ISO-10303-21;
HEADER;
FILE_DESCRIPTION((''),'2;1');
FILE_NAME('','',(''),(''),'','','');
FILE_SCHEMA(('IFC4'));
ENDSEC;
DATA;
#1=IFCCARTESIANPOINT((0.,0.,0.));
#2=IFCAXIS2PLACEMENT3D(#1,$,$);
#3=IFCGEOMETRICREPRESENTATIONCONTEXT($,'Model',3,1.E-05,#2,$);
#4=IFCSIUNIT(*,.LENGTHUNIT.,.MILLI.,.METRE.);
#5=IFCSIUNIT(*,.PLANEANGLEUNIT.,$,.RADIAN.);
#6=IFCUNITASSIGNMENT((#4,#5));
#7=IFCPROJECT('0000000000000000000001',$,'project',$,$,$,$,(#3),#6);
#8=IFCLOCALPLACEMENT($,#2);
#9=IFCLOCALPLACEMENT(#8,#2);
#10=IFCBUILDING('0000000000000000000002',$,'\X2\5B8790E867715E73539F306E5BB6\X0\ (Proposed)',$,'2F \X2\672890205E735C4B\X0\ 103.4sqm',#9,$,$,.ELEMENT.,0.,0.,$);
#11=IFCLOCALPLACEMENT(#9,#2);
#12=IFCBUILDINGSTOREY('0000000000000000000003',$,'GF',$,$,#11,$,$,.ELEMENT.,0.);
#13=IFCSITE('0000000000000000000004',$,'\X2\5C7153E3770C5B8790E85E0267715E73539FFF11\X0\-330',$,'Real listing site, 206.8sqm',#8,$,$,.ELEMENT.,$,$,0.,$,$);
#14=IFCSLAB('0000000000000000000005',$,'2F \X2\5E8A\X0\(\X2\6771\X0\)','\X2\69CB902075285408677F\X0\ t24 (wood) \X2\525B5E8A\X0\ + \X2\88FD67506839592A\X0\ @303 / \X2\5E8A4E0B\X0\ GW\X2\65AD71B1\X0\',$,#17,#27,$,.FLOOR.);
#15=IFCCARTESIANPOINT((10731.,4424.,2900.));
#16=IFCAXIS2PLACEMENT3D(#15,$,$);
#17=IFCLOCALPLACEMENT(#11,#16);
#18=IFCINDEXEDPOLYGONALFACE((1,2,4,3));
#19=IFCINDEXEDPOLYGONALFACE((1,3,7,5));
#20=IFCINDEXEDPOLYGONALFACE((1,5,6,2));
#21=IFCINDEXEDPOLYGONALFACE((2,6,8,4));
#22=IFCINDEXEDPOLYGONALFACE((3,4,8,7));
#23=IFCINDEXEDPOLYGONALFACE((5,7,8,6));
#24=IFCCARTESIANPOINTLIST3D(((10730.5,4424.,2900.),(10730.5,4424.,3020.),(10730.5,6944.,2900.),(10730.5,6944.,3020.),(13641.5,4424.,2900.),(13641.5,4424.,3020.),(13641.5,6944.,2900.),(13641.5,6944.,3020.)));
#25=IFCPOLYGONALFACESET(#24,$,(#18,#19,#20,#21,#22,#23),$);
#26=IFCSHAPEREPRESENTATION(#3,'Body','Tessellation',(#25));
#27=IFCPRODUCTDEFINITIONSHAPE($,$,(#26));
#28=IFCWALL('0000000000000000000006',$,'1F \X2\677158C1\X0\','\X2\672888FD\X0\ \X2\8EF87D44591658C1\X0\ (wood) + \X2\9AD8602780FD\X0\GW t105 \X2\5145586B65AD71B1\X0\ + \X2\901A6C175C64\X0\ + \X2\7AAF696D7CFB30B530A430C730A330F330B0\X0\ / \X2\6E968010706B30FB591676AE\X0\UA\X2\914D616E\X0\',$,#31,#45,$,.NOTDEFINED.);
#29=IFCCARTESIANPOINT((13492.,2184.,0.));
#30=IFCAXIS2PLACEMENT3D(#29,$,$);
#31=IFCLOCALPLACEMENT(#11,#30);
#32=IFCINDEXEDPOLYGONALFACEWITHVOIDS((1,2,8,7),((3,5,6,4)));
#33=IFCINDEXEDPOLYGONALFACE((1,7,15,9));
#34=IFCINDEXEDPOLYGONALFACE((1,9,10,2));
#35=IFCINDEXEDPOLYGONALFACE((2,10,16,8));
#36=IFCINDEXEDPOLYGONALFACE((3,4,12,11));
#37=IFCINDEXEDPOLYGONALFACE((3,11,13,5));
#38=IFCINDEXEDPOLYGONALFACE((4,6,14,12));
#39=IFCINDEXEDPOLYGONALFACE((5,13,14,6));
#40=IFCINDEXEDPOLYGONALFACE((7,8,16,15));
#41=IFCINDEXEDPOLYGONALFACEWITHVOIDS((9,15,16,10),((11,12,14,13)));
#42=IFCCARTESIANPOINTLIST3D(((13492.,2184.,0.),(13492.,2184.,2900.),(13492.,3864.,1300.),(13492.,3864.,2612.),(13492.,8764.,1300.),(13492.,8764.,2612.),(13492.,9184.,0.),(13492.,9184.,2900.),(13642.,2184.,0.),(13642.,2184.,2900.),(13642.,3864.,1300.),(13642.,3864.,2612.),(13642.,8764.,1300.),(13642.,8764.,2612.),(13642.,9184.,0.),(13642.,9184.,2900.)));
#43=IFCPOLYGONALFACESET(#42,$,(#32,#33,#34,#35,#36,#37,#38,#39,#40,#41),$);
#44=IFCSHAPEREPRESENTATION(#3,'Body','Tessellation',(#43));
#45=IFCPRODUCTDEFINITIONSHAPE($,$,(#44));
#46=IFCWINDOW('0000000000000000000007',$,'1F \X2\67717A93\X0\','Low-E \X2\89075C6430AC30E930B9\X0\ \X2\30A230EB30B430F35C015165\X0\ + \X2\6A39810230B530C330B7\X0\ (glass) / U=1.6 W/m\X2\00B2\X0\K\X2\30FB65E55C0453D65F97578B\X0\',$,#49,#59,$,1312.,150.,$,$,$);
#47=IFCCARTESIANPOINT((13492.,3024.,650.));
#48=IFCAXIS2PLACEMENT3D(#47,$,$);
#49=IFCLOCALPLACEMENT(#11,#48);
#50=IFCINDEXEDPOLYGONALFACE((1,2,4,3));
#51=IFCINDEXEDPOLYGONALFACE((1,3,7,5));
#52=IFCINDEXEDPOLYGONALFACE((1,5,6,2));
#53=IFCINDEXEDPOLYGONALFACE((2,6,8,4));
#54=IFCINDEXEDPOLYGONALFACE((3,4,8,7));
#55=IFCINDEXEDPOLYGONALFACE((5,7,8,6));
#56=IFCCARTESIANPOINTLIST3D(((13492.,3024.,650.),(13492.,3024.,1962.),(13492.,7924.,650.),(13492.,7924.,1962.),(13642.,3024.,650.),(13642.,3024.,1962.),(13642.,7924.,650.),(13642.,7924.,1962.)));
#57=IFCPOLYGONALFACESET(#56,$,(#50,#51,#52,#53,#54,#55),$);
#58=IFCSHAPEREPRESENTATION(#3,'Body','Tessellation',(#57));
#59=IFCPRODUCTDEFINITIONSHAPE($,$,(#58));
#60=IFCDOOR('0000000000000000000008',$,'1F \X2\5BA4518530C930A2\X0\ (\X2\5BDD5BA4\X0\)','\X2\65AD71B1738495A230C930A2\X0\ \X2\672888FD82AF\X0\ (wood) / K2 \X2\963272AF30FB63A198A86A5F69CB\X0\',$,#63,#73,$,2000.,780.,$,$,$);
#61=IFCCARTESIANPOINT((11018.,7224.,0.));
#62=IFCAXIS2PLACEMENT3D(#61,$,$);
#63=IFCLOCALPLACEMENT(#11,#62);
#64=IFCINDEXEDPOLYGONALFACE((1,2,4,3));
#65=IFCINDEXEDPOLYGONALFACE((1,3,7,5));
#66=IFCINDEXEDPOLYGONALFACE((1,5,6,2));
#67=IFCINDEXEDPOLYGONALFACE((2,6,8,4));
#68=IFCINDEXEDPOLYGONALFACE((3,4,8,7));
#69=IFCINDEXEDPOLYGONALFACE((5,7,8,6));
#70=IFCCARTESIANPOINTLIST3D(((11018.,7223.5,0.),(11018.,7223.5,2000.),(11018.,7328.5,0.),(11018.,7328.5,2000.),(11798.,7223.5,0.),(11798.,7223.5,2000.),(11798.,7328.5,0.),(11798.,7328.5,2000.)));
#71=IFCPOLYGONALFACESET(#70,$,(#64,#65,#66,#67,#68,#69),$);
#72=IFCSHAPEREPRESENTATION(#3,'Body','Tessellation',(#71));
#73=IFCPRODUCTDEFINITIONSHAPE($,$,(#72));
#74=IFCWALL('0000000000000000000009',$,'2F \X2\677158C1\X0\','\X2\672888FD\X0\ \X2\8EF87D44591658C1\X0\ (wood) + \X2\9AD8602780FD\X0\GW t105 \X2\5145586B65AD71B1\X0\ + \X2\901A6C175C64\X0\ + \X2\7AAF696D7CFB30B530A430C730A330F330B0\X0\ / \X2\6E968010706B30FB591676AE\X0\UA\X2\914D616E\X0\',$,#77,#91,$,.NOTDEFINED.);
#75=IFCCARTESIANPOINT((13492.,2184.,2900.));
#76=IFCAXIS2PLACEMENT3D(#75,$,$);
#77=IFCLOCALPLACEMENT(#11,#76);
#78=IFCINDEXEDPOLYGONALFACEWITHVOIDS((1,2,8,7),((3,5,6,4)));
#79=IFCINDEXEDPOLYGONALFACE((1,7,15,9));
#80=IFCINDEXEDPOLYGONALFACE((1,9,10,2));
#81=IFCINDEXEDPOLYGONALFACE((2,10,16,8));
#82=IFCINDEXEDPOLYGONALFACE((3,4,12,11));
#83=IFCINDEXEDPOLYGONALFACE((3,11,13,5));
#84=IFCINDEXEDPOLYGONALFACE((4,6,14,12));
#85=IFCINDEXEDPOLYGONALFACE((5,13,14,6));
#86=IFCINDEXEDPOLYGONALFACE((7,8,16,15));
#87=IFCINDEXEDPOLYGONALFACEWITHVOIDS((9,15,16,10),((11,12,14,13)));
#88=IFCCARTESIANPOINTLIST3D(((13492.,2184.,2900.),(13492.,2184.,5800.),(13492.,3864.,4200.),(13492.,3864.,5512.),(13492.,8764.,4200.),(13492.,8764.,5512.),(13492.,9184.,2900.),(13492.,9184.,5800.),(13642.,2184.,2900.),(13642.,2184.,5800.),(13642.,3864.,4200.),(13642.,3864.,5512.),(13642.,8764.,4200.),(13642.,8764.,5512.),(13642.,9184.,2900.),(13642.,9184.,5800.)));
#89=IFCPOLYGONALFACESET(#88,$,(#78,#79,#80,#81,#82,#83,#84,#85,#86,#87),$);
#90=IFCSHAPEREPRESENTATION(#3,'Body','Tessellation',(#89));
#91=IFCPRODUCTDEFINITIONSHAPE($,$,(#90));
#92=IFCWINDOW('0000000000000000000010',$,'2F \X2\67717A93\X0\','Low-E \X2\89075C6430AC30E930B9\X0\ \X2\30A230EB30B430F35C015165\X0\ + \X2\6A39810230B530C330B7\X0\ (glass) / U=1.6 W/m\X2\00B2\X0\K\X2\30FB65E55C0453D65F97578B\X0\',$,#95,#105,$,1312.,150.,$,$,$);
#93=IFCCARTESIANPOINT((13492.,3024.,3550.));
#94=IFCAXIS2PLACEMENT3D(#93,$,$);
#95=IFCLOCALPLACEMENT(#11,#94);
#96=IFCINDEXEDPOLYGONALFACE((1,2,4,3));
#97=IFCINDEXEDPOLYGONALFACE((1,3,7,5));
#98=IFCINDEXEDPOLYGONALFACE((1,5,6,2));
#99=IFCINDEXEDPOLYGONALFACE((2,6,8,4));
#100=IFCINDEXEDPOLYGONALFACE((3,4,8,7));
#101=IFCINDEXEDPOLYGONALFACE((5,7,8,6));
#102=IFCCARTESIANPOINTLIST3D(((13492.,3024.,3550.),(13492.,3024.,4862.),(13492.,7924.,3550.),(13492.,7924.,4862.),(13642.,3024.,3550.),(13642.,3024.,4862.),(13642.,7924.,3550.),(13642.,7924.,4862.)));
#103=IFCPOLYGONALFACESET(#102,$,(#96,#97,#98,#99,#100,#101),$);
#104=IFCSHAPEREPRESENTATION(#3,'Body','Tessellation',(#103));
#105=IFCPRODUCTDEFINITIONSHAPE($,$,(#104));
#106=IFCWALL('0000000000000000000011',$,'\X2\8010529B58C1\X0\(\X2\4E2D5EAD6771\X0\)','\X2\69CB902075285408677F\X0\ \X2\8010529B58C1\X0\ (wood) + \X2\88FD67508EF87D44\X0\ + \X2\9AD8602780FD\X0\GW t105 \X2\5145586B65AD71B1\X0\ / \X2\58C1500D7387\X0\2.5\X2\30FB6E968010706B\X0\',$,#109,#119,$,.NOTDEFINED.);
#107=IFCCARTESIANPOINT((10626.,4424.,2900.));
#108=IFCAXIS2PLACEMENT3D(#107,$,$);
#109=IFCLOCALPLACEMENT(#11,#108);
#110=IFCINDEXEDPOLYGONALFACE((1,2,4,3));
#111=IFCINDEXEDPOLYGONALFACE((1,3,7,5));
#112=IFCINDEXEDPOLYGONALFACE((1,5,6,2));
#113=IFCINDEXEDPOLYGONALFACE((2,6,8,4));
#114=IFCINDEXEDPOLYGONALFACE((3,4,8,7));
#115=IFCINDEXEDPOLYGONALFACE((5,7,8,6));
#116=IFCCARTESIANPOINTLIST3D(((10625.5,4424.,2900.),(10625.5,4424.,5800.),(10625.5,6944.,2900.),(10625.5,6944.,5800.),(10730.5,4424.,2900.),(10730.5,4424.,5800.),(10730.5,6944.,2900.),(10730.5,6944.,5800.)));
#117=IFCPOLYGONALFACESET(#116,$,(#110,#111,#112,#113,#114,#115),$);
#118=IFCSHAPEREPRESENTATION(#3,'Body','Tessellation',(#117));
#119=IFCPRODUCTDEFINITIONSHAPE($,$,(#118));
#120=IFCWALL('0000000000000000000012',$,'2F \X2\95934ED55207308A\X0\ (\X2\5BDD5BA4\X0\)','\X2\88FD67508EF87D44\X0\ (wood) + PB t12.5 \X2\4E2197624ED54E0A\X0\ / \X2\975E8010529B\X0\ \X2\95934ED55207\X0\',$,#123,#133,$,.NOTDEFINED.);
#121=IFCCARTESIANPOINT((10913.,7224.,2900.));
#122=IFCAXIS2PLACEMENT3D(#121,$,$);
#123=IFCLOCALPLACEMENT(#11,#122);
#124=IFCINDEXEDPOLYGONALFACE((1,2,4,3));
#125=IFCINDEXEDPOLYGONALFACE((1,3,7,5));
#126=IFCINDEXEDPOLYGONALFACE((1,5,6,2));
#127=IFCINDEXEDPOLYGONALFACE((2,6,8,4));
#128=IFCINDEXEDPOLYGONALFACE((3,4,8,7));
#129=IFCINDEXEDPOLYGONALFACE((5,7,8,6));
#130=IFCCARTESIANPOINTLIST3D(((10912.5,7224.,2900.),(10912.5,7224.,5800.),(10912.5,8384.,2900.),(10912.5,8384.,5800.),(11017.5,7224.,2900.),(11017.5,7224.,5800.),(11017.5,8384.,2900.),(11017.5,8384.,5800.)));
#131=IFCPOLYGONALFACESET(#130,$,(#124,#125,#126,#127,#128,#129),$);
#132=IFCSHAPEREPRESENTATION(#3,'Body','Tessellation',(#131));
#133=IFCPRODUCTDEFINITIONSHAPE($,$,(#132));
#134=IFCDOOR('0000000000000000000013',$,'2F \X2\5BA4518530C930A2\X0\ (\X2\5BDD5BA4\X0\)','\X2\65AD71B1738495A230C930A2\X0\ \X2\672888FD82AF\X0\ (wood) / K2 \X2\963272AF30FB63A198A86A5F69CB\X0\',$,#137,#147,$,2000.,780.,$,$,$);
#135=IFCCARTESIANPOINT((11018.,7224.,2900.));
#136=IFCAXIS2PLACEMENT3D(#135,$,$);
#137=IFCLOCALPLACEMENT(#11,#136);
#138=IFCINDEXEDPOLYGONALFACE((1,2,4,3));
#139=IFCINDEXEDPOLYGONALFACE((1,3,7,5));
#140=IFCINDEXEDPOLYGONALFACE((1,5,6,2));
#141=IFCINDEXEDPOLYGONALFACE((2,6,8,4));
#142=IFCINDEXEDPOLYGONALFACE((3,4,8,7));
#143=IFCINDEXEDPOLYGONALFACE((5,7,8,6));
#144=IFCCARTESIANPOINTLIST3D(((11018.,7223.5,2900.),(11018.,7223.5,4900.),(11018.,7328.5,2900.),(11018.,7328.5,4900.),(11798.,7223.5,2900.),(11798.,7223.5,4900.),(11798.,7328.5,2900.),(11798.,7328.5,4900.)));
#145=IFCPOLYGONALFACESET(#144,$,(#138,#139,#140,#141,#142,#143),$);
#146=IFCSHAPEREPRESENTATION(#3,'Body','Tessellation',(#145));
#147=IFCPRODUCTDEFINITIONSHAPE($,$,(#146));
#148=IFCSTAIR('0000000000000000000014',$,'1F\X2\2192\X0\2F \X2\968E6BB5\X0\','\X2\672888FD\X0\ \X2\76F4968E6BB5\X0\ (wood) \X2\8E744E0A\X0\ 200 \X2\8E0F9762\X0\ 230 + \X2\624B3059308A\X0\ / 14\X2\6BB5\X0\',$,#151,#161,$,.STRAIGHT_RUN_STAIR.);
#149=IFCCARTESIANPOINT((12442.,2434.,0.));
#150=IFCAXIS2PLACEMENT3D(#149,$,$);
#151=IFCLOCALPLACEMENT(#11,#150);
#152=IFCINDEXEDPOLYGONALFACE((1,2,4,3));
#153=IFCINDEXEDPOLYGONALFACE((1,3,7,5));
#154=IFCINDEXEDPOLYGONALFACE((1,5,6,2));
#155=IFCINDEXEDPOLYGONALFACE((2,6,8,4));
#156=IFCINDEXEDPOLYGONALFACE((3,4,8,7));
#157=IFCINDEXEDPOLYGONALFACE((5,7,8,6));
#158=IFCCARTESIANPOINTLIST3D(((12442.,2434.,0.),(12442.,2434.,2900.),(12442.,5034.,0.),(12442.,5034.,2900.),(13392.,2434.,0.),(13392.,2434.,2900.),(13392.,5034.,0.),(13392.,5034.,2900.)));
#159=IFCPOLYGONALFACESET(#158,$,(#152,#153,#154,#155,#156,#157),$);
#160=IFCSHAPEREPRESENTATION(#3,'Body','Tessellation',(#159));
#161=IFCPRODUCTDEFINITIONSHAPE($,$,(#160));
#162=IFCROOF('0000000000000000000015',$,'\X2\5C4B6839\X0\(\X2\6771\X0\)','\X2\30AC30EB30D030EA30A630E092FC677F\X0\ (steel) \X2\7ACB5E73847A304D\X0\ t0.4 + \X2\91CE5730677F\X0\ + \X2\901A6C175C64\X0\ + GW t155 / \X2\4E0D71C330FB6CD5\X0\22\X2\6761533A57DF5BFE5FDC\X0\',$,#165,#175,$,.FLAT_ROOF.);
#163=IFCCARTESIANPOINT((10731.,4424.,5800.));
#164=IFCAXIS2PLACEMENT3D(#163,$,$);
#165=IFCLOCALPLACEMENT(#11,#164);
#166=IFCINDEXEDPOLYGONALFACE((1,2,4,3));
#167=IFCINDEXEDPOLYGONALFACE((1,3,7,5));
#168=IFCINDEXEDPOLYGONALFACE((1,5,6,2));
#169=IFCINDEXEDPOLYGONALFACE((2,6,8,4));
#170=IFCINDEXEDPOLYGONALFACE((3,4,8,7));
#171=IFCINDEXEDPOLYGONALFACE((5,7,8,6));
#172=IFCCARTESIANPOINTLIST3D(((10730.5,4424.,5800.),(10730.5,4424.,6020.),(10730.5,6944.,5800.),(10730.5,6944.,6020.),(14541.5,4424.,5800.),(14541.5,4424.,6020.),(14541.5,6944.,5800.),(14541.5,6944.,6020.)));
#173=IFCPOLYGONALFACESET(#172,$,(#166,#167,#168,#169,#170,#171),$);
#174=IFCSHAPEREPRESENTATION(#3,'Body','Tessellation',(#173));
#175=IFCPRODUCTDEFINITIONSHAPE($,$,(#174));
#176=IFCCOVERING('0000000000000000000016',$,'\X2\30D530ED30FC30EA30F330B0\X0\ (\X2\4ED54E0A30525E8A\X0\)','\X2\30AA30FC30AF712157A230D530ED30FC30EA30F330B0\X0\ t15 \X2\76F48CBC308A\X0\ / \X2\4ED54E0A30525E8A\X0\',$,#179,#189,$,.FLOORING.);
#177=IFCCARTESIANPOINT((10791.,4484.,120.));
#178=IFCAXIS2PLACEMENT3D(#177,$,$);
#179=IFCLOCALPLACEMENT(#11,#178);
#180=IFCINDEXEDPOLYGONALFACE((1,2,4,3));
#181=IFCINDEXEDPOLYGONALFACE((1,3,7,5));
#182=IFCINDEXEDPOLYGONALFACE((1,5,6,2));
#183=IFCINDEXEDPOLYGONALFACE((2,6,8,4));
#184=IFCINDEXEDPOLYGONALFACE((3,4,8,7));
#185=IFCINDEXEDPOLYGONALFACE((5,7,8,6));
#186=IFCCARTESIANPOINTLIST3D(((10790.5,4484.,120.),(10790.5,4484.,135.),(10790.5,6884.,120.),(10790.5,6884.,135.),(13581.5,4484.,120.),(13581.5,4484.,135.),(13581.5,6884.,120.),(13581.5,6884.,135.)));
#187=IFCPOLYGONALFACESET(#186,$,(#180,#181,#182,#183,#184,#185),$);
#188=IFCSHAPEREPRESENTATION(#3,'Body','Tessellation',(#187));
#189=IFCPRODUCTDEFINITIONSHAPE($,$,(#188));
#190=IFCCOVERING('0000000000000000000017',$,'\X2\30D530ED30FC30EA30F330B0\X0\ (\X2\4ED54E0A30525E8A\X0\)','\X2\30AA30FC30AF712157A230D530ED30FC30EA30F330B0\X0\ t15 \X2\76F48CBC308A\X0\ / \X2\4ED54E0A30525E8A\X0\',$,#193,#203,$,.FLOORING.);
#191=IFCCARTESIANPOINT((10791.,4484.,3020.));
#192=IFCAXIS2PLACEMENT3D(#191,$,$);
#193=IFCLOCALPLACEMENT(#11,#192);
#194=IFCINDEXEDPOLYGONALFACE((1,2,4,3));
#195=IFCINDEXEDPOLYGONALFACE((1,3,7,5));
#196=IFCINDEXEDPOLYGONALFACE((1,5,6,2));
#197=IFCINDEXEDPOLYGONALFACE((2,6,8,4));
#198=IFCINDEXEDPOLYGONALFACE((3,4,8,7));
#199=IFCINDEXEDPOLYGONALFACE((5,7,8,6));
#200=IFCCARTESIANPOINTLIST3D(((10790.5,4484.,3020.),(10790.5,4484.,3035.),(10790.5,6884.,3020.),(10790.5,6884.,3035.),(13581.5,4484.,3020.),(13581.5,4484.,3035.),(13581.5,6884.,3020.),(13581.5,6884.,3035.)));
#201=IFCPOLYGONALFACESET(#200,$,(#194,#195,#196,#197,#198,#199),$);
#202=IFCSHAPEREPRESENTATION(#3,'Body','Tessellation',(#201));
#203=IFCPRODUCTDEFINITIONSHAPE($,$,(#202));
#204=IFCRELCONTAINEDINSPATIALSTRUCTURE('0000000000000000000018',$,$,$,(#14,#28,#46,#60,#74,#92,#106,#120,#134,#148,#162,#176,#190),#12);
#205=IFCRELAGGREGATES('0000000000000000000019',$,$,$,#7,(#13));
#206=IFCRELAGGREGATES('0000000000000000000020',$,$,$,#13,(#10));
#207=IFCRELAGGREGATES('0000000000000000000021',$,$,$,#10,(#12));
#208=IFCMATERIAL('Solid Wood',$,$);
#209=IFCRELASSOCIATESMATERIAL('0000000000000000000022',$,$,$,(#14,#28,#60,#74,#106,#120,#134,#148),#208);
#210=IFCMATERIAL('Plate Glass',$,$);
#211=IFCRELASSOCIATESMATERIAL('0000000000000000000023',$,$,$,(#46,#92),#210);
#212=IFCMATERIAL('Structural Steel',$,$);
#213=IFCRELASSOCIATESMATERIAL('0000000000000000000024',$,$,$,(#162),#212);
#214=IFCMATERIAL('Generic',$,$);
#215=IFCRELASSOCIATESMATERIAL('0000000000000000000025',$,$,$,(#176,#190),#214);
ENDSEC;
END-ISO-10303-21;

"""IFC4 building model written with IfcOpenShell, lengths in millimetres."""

from ifc_helpers import new_model, si_unit, frame, frame_2d, origin, place, context, project, spatial, rectangle, extrude, material, element, fill, save


model = new_model("IFC4")

# Units and contexts
model_context = context("Model", 3, precision=1e-05, world=origin())
ifc_project = project(units=[si_unit("LENGTHUNIT", "METRE", prefix="MILLI"), si_unit("PLANEANGLEUNIT", "RADIAN")], contexts=[model_context])

# Site, building, storey
site_placement = place(None, origin())
site = spatial("IfcSite", under=ifc_project, at=site_placement, Name="山口県宇部市東平原１-330", ObjectType="Real listing site, 206.8sqm", CompositionType="ELEMENT", RefElevation=0.0)
building_placement = place(site_placement, origin())
building = spatial("IfcBuilding", under=site, at=building_placement, Name="宇部東平原の家 (Proposed)", ObjectType="2F 木造平屋 103.4sqm", CompositionType="ELEMENT", ElevationOfRefHeight=0.0, ElevationOfTerrain=0.0)
storey_placement = place(building_placement, origin())
storey = spatial("IfcBuildingStorey", under=building, at=storey_placement, Name="GF", CompositionType="ELEMENT", Elevation=0.0)

# Slab
ifc_material_1 = material(Name="Solid Wood")
slab_1_placement = place(storey_placement, frame((10731.0, 4424.0, 2900.0)))
element("IfcSlab", 1, at=slab_1_placement, inside=storey, material=ifc_material_1, Name="2F 床(東)", Description="構造用合板 t24 (wood) 剛床 + 製材根太 @303 / 床下 GW断熱", PredefinedType="FLOOR", context=model_context, shape_type="SweptSolid", body=[
    extrude(rectangle(XDim=2911.0, YDim=2520.0, at=frame_2d((1455.0, 1260.0))), frame((10731.0, 4424.0, 2900.0)), (0.0, 0.0, 1.0), 120.0),
])

# Wall, opening, window
wall_1_placement = place(storey_placement, frame((13492.0, 2184.0, 0.0)))
wall_1 = element("IfcWall", 2, at=wall_1_placement, inside=storey, material=ifc_material_1, Name="1F 東壁", Description="木製 軸組外壁 (wood) + 高性能GW t105 充填断熱 + 通気層 + 窯業系サイディング / 準耐火・外皮UA配慮", PredefinedType="NOTDEFINED", context=model_context, shape_type="SweptSolid", body=[
    extrude(rectangle(XDim=150.0, YDim=7000.0, at=frame_2d((75.0, 3500.0))), frame((13492.0, 2184.0, 0.0)), (0.0, 0.0, 1.0), 2900.0),
])
opening_1_placement = place(storey_placement, frame((13492.0, 3024.0, 650.0)))
opening_1 = element("IfcOpeningElement", 3, at=opening_1_placement, cuts=wall_1, PredefinedType="NOTDEFINED", context=model_context, shape_type="SweptSolid", body=[
    extrude(rectangle(XDim=150.0, YDim=4900.0, at=frame_2d((75.0, 2450.0))), frame((13492.0, 3024.0, 650.0)), (0.0, 0.0, 1.0), 1312.0),
])
ifc_material_2 = material(Name="Plate Glass")
window_1_placement = place(storey_placement, frame((13492.0, 3024.0, 650.0)))
window_1 = element("IfcWindow", 4, at=window_1_placement, inside=storey, material=ifc_material_2, Name="1F 東窓", Description="Low-E 複層ガラス アルゴン封入 + 樹脂サッシ (glass) / U=1.6 W/m²K・日射取得型", OverallHeight=1312.0, OverallWidth=150.0, context=model_context, shape_type="SweptSolid", body=[
    extrude(rectangle(XDim=150.0, YDim=4900.0, at=frame_2d((75.0, 2450.0))), frame((13492.0, 3024.0, 650.0)), (0.0, 0.0, 1.0), 1312.0),
])
fill(opening_1, window_1)

# Door
door_1_placement = place(storey_placement, frame((11018.0, 7224.0, 0.0)))
element("IfcDoor", 5, at=door_1_placement, inside=storey, material=ifc_material_1, Name="1F 室内ドア (寝室)", Description="断熱玄関ドア 木製芯 (wood) / K2 防犯・採風機構", OverallHeight=2000.0, OverallWidth=780.0, context=model_context, shape_type="SweptSolid", body=[
    extrude(rectangle(XDim=780.0, YDim=105.0, at=frame_2d((390.0, 52.0))), frame((11018.0, 7224.0, 0.0)), (0.0, 0.0, 1.0), 2000.0),
])

# Wall, opening, window
wall_2_placement = place(storey_placement, frame((13492.0, 2184.0, 2900.0)))
wall_2 = element("IfcWall", 6, at=wall_2_placement, inside=storey, material=ifc_material_1, Name="2F 東壁", Description="木製 軸組外壁 (wood) + 高性能GW t105 充填断熱 + 通気層 + 窯業系サイディング / 準耐火・外皮UA配慮", PredefinedType="NOTDEFINED", context=model_context, shape_type="SweptSolid", body=[
    extrude(rectangle(XDim=150.0, YDim=7000.0, at=frame_2d((75.0, 3500.0))), frame((13492.0, 2184.0, 2900.0)), (0.0, 0.0, 1.0), 2900.0),
])
opening_2_placement = place(storey_placement, frame((13492.0, 3024.0, 3550.0)))
opening_2 = element("IfcOpeningElement", 7, at=opening_2_placement, cuts=wall_2, PredefinedType="NOTDEFINED", context=model_context, shape_type="SweptSolid", body=[
    extrude(rectangle(XDim=150.0, YDim=4900.0, at=frame_2d((75.0, 2450.0))), frame((13492.0, 3024.0, 3550.0)), (0.0, 0.0, 1.0), 1312.0),
])
window_2_placement = place(storey_placement, frame((13492.0, 3024.0, 3550.0)))
window_2 = element("IfcWindow", 8, at=window_2_placement, inside=storey, material=ifc_material_2, Name="2F 東窓", Description="Low-E 複層ガラス アルゴン封入 + 樹脂サッシ (glass) / U=1.6 W/m²K・日射取得型", OverallHeight=1312.0, OverallWidth=150.0, context=model_context, shape_type="SweptSolid", body=[
    extrude(rectangle(XDim=150.0, YDim=4900.0, at=frame_2d((75.0, 2450.0))), frame((13492.0, 3024.0, 3550.0)), (0.0, 0.0, 1.0), 1312.0),
])
fill(opening_2, window_2)

# Walls
wall_3_placement = place(storey_placement, frame((10626.0, 4424.0, 2900.0)))
element("IfcWall", 9, at=wall_3_placement, inside=storey, material=ifc_material_1, Name="耐力壁(中庭東)", Description="構造用合板 耐力壁 (wood) + 製材軸組 + 高性能GW t105 充填断熱 / 壁倍率2.5・準耐火", PredefinedType="NOTDEFINED", context=model_context, shape_type="SweptSolid", body=[
    extrude(rectangle(XDim=105.0, YDim=2520.0, at=frame_2d((52.0, 1260.0))), frame((10626.0, 4424.0, 2900.0)), (0.0, 0.0, 1.0), 2900.0),
])
wall_4_placement = place(storey_placement, frame((10913.0, 7224.0, 2900.0)))
element("IfcWall", 10, at=wall_4_placement, inside=storey, material=ifc_material_1, Name="2F 間仕切り (寝室)", Description="製材軸組 (wood) + PB t12.5 両面仕上 / 非耐力 間仕切", PredefinedType="NOTDEFINED", context=model_context, shape_type="SweptSolid", body=[
    extrude(rectangle(XDim=105.0, YDim=1160.0, at=frame_2d((52.0, 580.0))), frame((10913.0, 7224.0, 2900.0)), (0.0, 0.0, 1.0), 2900.0),
])

# Door
door_2_placement = place(storey_placement, frame((11018.0, 7224.0, 2900.0)))
element("IfcDoor", 11, at=door_2_placement, inside=storey, material=ifc_material_1, Name="2F 室内ドア (寝室)", Description="断熱玄関ドア 木製芯 (wood) / K2 防犯・採風機構", OverallHeight=2000.0, OverallWidth=780.0, context=model_context, shape_type="SweptSolid", body=[
    extrude(rectangle(XDim=780.0, YDim=105.0, at=frame_2d((390.0, 52.0))), frame((11018.0, 7224.0, 2900.0)), (0.0, 0.0, 1.0), 2000.0),
])

# Stair
stair_placement = place(storey_placement, frame((12442.0, 2434.0, 0.0)))
element("IfcStair", 12, at=stair_placement, inside=storey, material=ifc_material_1, Name="1F→2F 階段", Description="木製 直階段 (wood) 蹴上 200 踏面 230 + 手すり / 14段", PredefinedType="STRAIGHT_RUN_STAIR", context=model_context, shape_type="SweptSolid", body=[
    extrude(rectangle(XDim=950.0, YDim=2600.0, at=frame_2d((475.0, 1300.0))), frame((12442.0, 2434.0, 0.0)), (0.0, 0.0, 1.0), 2900.0),
])

# Roof
ifc_material_3 = material(Name="Structural Steel")
for number, where, name in (
    (13, (10731.0, 4424.0, 5800.0), "屋根(東)"),
):
    element("IfcRoof", number, at=place(storey_placement, frame(where)), inside=storey, material=ifc_material_3, Name=name, Description="ガルバリウム鋼板 (steel) 立平葺き t0.4 + 野地板 + 通気層 + GW t155 / 不燃・法22条区域対応", PredefinedType="FLAT_ROOF", context=model_context, shape_type="SweptSolid", body=[
        extrude(rectangle(XDim=3811.0, YDim=2520.0, at=frame_2d((1905.0, 1260.0))), frame((10731.0, 4424.0, 5800.0)), (0.0, 0.0, 1.0), 220.0),
    ])

# Coverings
ifc_material_4 = material(Name="Generic")
covering_1_placement = place(storey_placement, frame((10791.0, 4484.0, 120.0)))
element("IfcCovering", 14, at=covering_1_placement, inside=storey, material=ifc_material_4, Name="フローリング (仕上げ床)", Description="オーク無垢フローリング t15 直貼り / 仕上げ床", PredefinedType="FLOORING", context=model_context, shape_type="SweptSolid", body=[
    extrude(rectangle(XDim=2791.0, YDim=2400.0, at=frame_2d((1395.0, 1200.0))), frame((10791.0, 4484.0, 120.0)), (0.0, 0.0, 1.0), 15.0),
])
covering_2_placement = place(storey_placement, frame((10791.0, 4484.0, 3020.0)))
element("IfcCovering", 15, at=covering_2_placement, inside=storey, material=ifc_material_4, Name="フローリング (仕上げ床)", Description="オーク無垢フローリング t15 直貼り / 仕上げ床", PredefinedType="FLOORING", context=model_context, shape_type="SweptSolid", body=[
    extrude(rectangle(XDim=2791.0, YDim=2400.0, at=frame_2d((1395.0, 1200.0))), frame((10791.0, 4484.0, 3020.0)), (0.0, 0.0, 1.0), 15.0),
])

save(model, "model.ifc")
